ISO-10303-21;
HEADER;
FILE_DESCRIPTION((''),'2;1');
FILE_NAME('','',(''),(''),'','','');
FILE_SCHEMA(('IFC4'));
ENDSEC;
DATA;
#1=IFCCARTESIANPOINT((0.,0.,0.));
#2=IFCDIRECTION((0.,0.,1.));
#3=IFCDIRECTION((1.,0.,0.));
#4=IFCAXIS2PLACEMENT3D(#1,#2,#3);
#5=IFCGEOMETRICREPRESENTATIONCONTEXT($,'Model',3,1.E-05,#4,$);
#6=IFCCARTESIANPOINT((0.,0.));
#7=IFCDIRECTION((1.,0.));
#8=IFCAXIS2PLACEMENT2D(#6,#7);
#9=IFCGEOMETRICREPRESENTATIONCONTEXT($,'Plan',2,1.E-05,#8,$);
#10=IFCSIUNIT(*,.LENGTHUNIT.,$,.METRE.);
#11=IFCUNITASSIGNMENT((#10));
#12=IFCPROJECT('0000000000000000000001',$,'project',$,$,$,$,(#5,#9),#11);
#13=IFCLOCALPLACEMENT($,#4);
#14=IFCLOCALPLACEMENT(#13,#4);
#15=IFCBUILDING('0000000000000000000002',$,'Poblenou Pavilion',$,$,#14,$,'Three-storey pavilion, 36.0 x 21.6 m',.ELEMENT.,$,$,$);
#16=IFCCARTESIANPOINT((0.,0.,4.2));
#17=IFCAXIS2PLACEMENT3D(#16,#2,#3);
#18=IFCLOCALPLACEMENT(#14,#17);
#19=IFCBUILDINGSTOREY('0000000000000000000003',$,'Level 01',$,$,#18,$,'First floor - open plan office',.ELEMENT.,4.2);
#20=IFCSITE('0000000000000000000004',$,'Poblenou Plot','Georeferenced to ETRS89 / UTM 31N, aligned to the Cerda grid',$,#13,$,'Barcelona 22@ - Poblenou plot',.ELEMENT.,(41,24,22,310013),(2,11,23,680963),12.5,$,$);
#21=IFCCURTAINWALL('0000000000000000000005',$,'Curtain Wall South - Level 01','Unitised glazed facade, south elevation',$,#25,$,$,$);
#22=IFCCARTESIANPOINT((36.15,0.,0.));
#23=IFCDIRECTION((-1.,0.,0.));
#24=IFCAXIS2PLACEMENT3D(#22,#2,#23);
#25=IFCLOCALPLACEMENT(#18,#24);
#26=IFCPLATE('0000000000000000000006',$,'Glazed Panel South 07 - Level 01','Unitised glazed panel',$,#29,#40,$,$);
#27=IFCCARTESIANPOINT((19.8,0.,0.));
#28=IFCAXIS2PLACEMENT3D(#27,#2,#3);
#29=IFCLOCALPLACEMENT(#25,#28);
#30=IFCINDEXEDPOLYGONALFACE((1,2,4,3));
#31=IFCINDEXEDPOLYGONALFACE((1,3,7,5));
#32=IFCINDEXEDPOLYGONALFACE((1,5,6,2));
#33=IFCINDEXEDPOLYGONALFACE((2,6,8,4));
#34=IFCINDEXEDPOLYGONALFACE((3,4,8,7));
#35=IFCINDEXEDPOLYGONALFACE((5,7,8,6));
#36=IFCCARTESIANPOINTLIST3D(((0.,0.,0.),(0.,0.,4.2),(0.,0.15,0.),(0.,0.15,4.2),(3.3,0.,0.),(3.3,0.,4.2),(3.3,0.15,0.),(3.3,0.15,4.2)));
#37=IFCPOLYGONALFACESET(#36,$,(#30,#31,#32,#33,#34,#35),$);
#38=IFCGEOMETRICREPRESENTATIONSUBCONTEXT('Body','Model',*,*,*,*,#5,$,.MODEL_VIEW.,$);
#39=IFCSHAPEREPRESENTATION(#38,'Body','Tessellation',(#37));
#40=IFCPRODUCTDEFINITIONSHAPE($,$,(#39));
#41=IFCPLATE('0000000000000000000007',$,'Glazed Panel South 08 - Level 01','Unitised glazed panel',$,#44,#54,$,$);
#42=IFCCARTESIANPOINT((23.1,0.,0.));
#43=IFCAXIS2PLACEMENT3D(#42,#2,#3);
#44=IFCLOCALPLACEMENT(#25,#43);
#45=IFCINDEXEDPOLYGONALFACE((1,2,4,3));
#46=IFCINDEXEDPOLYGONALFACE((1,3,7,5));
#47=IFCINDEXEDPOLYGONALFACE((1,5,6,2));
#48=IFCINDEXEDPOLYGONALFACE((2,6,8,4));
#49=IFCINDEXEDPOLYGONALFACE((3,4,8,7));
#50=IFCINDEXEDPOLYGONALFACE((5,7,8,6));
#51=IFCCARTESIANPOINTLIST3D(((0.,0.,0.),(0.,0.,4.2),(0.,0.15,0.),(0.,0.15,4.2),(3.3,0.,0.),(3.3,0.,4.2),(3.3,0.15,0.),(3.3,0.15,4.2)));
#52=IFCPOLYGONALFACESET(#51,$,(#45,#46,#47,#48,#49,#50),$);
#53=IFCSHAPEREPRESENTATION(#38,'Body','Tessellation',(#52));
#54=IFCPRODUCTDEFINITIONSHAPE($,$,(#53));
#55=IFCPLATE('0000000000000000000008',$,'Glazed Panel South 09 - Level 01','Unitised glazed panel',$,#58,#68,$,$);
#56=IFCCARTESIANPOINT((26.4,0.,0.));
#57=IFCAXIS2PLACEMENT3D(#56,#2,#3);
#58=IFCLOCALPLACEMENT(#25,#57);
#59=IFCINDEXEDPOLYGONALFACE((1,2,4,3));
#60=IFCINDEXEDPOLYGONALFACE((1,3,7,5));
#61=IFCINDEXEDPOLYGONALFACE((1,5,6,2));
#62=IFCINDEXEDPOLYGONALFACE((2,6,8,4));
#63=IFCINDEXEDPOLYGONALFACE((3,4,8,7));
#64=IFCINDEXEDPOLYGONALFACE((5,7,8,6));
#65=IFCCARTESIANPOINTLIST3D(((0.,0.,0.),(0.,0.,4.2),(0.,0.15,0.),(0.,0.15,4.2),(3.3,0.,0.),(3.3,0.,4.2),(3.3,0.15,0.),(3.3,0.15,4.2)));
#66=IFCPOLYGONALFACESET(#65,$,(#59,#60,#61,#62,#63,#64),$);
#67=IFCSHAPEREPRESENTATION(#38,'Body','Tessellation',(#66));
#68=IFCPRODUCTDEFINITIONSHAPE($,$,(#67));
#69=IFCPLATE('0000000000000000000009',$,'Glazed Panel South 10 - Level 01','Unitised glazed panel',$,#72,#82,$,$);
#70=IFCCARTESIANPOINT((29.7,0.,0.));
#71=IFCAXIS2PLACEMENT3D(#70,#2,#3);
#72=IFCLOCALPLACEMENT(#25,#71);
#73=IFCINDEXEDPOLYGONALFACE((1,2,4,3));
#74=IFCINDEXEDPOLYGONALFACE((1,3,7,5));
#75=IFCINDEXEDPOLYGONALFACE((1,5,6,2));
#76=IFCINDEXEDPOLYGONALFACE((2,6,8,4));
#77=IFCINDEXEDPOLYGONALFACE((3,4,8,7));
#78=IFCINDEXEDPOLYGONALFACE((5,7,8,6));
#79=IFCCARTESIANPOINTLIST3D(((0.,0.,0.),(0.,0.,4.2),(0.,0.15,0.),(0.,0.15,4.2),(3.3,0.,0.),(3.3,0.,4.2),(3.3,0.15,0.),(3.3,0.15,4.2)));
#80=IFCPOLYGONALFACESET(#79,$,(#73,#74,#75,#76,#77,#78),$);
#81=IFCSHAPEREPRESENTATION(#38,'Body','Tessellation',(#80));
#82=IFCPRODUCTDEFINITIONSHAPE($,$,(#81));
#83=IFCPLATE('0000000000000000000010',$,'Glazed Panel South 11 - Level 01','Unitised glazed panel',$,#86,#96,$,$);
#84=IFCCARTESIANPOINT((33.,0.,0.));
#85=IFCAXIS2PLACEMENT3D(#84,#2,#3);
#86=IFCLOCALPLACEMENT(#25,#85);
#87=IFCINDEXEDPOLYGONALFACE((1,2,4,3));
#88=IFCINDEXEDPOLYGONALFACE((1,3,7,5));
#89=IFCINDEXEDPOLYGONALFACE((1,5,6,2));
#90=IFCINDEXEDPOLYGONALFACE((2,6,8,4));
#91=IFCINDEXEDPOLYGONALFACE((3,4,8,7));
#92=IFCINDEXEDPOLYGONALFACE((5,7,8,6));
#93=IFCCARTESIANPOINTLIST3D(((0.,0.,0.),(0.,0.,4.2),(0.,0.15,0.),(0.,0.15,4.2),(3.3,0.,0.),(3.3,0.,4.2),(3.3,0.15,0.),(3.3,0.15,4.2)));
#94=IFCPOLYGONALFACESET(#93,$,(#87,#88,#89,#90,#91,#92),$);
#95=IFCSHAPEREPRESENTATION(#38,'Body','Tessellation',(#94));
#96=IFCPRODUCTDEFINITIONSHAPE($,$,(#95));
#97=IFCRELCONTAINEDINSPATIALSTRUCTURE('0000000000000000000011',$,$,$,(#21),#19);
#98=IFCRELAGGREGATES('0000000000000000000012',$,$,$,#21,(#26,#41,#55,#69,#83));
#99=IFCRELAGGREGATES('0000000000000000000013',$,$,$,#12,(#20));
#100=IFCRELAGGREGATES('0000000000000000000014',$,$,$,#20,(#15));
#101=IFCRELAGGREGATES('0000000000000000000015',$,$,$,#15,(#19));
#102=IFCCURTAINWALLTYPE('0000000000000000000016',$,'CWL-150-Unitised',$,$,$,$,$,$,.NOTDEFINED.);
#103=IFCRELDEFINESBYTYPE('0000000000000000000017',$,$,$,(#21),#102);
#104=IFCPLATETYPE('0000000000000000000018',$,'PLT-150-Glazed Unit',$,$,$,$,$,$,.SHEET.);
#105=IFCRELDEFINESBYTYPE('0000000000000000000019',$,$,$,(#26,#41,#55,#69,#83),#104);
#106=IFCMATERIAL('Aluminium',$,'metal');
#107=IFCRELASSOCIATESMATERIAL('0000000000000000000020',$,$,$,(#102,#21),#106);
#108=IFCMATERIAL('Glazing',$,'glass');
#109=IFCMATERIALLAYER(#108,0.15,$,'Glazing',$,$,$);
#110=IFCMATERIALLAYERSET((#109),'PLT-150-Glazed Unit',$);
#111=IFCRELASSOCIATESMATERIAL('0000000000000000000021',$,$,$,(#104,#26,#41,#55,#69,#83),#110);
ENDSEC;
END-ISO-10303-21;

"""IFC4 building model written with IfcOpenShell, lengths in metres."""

from ifc_helpers import new_model, si_unit, frame, origin_with_axes, origin_2d_with_axis, place, context, subcontext, project, spatial, line, indexed_curve, outline, extrude, material, layer, layer_set, layer_usage, type_object, element, aggregate, save


model = new_model("IFC4")

# Units and contexts
model_context = context("Model", 3, precision=1e-05, world=origin_with_axes())
plan_context = context("Plan", 2, precision=1e-05, world=origin_2d_with_axis())
body_context = subcontext(model_context, "Body", "Model", "MODEL_VIEW")
ifc_project = project(units=[si_unit("LENGTHUNIT", "METRE")], contexts=[model_context, plan_context])

# Site, building, storey
site_placement = place(None, origin_with_axes())
site = spatial("IfcSite", under=ifc_project, at=site_placement, Name="Poblenou Plot", Description="Georeferenced to ETRS89 / UTM 31N, aligned to the Cerda grid", LongName="Barcelona 22@ - Poblenou plot", CompositionType="ELEMENT", RefLatitude=(41, 24, 22, 310013), RefLongitude=(2, 11, 23, 680963), RefElevation=12.5)
building_placement = place(site_placement, origin_with_axes())
building = spatial("IfcBuilding", under=site, at=building_placement, Name="Poblenou Pavilion", LongName="Three-storey pavilion, 36.0 x 21.6 m", CompositionType="ELEMENT")
storey_placement = place(building_placement, frame((0.0, 0.0, 4.2), z_axis=(0.0, 0.0, 1.0), x_axis=(1.0, 0.0, 0.0)))
storey = spatial("IfcBuildingStorey", under=building, at=storey_placement, Name="Level 01", LongName="First floor - open plan office", CompositionType="ELEMENT", Elevation=4.2)

# Curtain wall, plates
ifc_material_1 = material(Name="Aluminium", Category="metal")
curtain_wall_type = type_object("IfcCurtainWallType", Name="CWL-150-Unitised", PredefinedType="NOTDEFINED", material=ifc_material_1)
curtain_wall_1_placement = place(storey_placement, frame((36.15, 0.0, 0.0), z_axis=(0.0, 0.0, 1.0), x_axis=(-1.0, 0.0, 0.0)))
curtain_wall_1 = element("IfcCurtainWall", 1, at=curtain_wall_1_placement, inside=storey, type_object=curtain_wall_type, material=ifc_material_1, Name="Curtain Wall South - Level 01", Description="Unitised glazed facade, south elevation")
ifc_material_2 = material(Name="Glazing", Category="glass")
ifc_layer_1 = layer(ifc_material_2, 0.15, Name="Glazing")
ifc_layer_set_1 = layer_set([ifc_layer_1], Name="PLT-150-Glazed Unit")
ifc_layer_usage_1 = layer_usage(ifc_layer_set_1, "AXIS2", "POSITIVE", 0.0)
plate_type = type_object("IfcPlateType", Name="PLT-150-Glazed Unit", PredefinedType="SHEET", material=ifc_layer_set_1)
plate_1_placement = place(curtain_wall_1_placement, frame((19.8, 0.0, 0.0), z_axis=(0.0, 0.0, 1.0), x_axis=(1.0, 0.0, 0.0)))
plate_1 = element("IfcPlate", 2, at=plate_1_placement, type_object=plate_type, material=ifc_layer_usage_1, Name="Glazed Panel South 07 - Level 01", Description="Unitised glazed panel", context=body_context, shape_type="SweptSolid", body=[
    extrude(outline(indexed_curve([(0.0, 0.0), (3.3, 0.0), (3.3, 0.15), (0.0, 0.15)], segments=[line(1, 2, 3, 4, 1)])), origin_with_axes(), (0.0, 0.0, 1.0), 4.2),
])
ifc_layer_usage_2 = layer_usage(ifc_layer_set_1, "AXIS2", "POSITIVE", 0.0)
plate_2_placement = place(curtain_wall_1_placement, frame((23.1, 0.0, 0.0), z_axis=(0.0, 0.0, 1.0), x_axis=(1.0, 0.0, 0.0)))
plate_2 = element("IfcPlate", 3, at=plate_2_placement, type_object=plate_type, material=ifc_layer_usage_2, Name="Glazed Panel South 08 - Level 01", Description="Unitised glazed panel", context=body_context, shape_type="SweptSolid", body=[
    extrude(outline(indexed_curve([(0.0, 0.0), (3.3, 0.0), (3.3, 0.15), (0.0, 0.15)], segments=[line(1, 2, 3, 4, 1)])), origin_with_axes(), (0.0, 0.0, 1.0), 4.2),
])
ifc_layer_usage_3 = layer_usage(ifc_layer_set_1, "AXIS2", "POSITIVE", 0.0)
plate_3_placement = place(curtain_wall_1_placement, frame((26.4, 0.0, 0.0), z_axis=(0.0, 0.0, 1.0), x_axis=(1.0, 0.0, 0.0)))
plate_3 = element("IfcPlate", 4, at=plate_3_placement, type_object=plate_type, material=ifc_layer_usage_3, Name="Glazed Panel South 09 - Level 01", Description="Unitised glazed panel", context=body_context, shape_type="SweptSolid", body=[
    extrude(outline(indexed_curve([(0.0, 0.0), (3.3, 0.0), (3.3, 0.15), (0.0, 0.15)], segments=[line(1, 2, 3, 4, 1)])), origin_with_axes(), (0.0, 0.0, 1.0), 4.2),
])
ifc_layer_usage_4 = layer_usage(ifc_layer_set_1, "AXIS2", "POSITIVE", 0.0)
plate_4_placement = place(curtain_wall_1_placement, frame((29.7, 0.0, 0.0), z_axis=(0.0, 0.0, 1.0), x_axis=(1.0, 0.0, 0.0)))
plate_4 = element("IfcPlate", 5, at=plate_4_placement, type_object=plate_type, material=ifc_layer_usage_4, Name="Glazed Panel South 10 - Level 01", Description="Unitised glazed panel", context=body_context, shape_type="SweptSolid", body=[
    extrude(outline(indexed_curve([(0.0, 0.0), (3.3, 0.0), (3.3, 0.15), (0.0, 0.15)], segments=[line(1, 2, 3, 4, 1)])), origin_with_axes(), (0.0, 0.0, 1.0), 4.2),
])
ifc_layer_usage_5 = layer_usage(ifc_layer_set_1, "AXIS2", "POSITIVE", 0.0)
plate_5_placement = place(curtain_wall_1_placement, frame((33.0, 0.0, 0.0), z_axis=(0.0, 0.0, 1.0), x_axis=(1.0, 0.0, 0.0)))
plate_5 = element("IfcPlate", 6, at=plate_5_placement, type_object=plate_type, material=ifc_layer_usage_5, Name="Glazed Panel South 11 - Level 01", Description="Unitised glazed panel", context=body_context, shape_type="SweptSolid", body=[
    extrude(outline(indexed_curve([(0.0, 0.0), (3.3, 0.0), (3.3, 0.15), (0.0, 0.15)], segments=[line(1, 2, 3, 4, 1)])), origin_with_axes(), (0.0, 0.0, 1.0), 4.2),
])
aggregate(curtain_wall_1, [plate_1, plate_2, plate_3, plate_4, plate_5])

save(model, "model.ifc")
